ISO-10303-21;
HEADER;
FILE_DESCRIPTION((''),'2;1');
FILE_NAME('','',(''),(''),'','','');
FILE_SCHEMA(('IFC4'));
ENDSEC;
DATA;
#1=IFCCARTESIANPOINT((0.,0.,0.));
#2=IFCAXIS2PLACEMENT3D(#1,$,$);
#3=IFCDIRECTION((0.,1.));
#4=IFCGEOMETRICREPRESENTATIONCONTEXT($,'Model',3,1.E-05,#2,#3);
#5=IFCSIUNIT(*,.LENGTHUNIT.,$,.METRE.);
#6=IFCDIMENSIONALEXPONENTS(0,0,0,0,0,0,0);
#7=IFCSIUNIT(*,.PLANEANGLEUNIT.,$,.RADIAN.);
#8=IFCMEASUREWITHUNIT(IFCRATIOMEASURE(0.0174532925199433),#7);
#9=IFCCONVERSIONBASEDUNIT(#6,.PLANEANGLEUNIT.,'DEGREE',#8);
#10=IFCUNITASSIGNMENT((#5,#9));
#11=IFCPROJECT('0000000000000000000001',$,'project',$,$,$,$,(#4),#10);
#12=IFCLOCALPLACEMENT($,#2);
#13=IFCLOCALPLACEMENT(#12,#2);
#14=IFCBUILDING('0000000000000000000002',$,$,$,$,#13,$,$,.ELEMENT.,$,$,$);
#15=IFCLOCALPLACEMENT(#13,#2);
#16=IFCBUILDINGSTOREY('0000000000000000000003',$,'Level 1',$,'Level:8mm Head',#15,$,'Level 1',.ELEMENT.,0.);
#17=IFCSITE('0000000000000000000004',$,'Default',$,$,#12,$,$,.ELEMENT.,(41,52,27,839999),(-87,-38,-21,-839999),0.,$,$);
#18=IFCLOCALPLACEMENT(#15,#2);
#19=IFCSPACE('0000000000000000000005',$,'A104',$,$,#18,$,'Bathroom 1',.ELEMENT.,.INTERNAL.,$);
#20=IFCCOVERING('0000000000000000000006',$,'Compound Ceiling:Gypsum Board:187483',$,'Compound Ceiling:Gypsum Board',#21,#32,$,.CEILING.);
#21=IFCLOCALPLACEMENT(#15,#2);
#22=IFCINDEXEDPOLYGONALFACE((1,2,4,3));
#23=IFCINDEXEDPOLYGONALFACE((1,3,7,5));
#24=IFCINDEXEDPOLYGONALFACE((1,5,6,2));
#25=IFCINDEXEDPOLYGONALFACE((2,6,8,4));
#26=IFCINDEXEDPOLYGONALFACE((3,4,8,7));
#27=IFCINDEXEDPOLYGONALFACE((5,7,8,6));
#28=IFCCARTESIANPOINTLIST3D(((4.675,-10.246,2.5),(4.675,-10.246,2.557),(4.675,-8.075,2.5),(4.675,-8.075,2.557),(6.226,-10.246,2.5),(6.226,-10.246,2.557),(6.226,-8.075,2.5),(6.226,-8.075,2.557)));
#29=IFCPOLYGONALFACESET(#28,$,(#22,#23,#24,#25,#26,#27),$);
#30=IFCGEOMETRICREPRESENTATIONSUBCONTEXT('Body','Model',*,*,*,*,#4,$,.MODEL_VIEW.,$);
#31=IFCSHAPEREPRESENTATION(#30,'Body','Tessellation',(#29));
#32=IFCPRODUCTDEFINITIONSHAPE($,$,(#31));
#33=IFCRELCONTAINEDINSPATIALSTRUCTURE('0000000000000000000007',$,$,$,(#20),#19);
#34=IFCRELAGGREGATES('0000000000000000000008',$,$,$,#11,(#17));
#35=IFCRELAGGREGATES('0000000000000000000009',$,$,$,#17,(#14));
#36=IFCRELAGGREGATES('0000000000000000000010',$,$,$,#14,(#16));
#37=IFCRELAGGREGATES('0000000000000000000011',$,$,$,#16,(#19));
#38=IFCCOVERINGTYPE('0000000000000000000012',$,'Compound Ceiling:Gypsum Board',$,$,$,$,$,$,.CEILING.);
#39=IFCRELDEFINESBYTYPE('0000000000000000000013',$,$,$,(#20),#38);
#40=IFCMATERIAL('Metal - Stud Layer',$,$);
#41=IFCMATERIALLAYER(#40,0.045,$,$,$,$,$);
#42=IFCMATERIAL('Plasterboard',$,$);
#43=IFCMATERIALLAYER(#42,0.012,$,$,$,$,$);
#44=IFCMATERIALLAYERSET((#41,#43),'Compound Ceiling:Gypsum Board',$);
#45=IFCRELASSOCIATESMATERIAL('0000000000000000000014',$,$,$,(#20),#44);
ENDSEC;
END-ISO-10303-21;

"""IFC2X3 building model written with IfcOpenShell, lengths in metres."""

from ifc_helpers import new_model, entity, si_unit, converted_unit, direction, frame, frame_2d, origin, place, context, subcontext, project, spatial, rectangle, extrude, material, layer, layer_set, layer_usage, type_object, element, save


model = new_model("IFC2X3")

# Units and contexts
model_context = context("Model", 3, precision=1e-05, world=origin(), true_north=direction((0.0, 1.0)))
body_context = subcontext(model_context, "Body", "Model", "MODEL_VIEW")
ifc_project = project(units=[si_unit("LENGTHUNIT", "METRE"), converted_unit("PLANEANGLEUNIT", "DEGREE", entity("IfcRatioMeasure", 0.0174532925199433), si_unit("PLANEANGLEUNIT", "RADIAN"), dimensions=[0, 0, 0, 0, 0, 0, 0])], contexts=[model_context])

# Site, building, storey
site_placement = place(None, origin())
site = spatial("IfcSite", under=ifc_project, at=site_placement, Name="Default", CompositionType="ELEMENT", RefLatitude=(41, 52, 27, 839999), RefLongitude=(-87, -38, -21, -839999), RefElevation=0.0)
building_placement = place(site_placement, origin())
building = spatial("IfcBuilding", under=site, at=building_placement, CompositionType="ELEMENT")
storey_placement = place(building_placement, origin())
storey = spatial("IfcBuildingStorey", under=building, at=storey_placement, Name="Level 1", ObjectType="Level:8mm Head", LongName="Level 1", CompositionType="ELEMENT", Elevation=0.0)

# Shared definitions
ifc_material_1 = material(Name="Metal - Stud Layer")
ifc_material_2 = material(Name="Plasterboard")

# Shared definitions
ifc_layer_1 = layer(ifc_material_1, 0.045)
ifc_layer_2 = layer(ifc_material_2, 0.012)
ifc_layer_set_1 = layer_set([ifc_layer_1, ifc_layer_2], Name="Compound Ceiling:Gypsum Board")

# Shared definitions
space_1_placement = place(storey_placement, origin())
space_1 = spatial("IfcSpace", under=storey, at=space_1_placement, Name="A104", LongName="Bathroom 1", CompositionType="ELEMENT", InteriorOrExteriorSpace="INTERNAL")

# Covering
ifc_layer_usage_1 = layer_usage(ifc_layer_set_1, "AXIS3", "POSITIVE", 0.0)
covering_type_1 = type_object("IfcCoveringType", Name="Compound Ceiling:Gypsum Board", PredefinedType="CEILING")
covering_1_placement = place(space_1_placement, origin())
element("IfcCovering", 1, at=covering_1_placement, inside=space_1, type_object=covering_type_1, material=ifc_layer_usage_1, Name="Compound Ceiling:Gypsum Board:187483", ObjectType="Compound Ceiling:Gypsum Board", PredefinedType="CEILING", context=body_context, shape_type="SweptSolid", body=[
    extrude(rectangle(XDim=2.171, YDim=1.551, at=frame_2d((0.0, 0.0), x_axis=(1.0, 0.0))), frame((5.4505, -9.1605, 2.5), z_axis=(0.0, 0.0, 1.0), x_axis=(0.0, -1.0, 0.0)), (0.0, 0.0, 1.0), 0.057),
])

save(model, "model.ifc")
